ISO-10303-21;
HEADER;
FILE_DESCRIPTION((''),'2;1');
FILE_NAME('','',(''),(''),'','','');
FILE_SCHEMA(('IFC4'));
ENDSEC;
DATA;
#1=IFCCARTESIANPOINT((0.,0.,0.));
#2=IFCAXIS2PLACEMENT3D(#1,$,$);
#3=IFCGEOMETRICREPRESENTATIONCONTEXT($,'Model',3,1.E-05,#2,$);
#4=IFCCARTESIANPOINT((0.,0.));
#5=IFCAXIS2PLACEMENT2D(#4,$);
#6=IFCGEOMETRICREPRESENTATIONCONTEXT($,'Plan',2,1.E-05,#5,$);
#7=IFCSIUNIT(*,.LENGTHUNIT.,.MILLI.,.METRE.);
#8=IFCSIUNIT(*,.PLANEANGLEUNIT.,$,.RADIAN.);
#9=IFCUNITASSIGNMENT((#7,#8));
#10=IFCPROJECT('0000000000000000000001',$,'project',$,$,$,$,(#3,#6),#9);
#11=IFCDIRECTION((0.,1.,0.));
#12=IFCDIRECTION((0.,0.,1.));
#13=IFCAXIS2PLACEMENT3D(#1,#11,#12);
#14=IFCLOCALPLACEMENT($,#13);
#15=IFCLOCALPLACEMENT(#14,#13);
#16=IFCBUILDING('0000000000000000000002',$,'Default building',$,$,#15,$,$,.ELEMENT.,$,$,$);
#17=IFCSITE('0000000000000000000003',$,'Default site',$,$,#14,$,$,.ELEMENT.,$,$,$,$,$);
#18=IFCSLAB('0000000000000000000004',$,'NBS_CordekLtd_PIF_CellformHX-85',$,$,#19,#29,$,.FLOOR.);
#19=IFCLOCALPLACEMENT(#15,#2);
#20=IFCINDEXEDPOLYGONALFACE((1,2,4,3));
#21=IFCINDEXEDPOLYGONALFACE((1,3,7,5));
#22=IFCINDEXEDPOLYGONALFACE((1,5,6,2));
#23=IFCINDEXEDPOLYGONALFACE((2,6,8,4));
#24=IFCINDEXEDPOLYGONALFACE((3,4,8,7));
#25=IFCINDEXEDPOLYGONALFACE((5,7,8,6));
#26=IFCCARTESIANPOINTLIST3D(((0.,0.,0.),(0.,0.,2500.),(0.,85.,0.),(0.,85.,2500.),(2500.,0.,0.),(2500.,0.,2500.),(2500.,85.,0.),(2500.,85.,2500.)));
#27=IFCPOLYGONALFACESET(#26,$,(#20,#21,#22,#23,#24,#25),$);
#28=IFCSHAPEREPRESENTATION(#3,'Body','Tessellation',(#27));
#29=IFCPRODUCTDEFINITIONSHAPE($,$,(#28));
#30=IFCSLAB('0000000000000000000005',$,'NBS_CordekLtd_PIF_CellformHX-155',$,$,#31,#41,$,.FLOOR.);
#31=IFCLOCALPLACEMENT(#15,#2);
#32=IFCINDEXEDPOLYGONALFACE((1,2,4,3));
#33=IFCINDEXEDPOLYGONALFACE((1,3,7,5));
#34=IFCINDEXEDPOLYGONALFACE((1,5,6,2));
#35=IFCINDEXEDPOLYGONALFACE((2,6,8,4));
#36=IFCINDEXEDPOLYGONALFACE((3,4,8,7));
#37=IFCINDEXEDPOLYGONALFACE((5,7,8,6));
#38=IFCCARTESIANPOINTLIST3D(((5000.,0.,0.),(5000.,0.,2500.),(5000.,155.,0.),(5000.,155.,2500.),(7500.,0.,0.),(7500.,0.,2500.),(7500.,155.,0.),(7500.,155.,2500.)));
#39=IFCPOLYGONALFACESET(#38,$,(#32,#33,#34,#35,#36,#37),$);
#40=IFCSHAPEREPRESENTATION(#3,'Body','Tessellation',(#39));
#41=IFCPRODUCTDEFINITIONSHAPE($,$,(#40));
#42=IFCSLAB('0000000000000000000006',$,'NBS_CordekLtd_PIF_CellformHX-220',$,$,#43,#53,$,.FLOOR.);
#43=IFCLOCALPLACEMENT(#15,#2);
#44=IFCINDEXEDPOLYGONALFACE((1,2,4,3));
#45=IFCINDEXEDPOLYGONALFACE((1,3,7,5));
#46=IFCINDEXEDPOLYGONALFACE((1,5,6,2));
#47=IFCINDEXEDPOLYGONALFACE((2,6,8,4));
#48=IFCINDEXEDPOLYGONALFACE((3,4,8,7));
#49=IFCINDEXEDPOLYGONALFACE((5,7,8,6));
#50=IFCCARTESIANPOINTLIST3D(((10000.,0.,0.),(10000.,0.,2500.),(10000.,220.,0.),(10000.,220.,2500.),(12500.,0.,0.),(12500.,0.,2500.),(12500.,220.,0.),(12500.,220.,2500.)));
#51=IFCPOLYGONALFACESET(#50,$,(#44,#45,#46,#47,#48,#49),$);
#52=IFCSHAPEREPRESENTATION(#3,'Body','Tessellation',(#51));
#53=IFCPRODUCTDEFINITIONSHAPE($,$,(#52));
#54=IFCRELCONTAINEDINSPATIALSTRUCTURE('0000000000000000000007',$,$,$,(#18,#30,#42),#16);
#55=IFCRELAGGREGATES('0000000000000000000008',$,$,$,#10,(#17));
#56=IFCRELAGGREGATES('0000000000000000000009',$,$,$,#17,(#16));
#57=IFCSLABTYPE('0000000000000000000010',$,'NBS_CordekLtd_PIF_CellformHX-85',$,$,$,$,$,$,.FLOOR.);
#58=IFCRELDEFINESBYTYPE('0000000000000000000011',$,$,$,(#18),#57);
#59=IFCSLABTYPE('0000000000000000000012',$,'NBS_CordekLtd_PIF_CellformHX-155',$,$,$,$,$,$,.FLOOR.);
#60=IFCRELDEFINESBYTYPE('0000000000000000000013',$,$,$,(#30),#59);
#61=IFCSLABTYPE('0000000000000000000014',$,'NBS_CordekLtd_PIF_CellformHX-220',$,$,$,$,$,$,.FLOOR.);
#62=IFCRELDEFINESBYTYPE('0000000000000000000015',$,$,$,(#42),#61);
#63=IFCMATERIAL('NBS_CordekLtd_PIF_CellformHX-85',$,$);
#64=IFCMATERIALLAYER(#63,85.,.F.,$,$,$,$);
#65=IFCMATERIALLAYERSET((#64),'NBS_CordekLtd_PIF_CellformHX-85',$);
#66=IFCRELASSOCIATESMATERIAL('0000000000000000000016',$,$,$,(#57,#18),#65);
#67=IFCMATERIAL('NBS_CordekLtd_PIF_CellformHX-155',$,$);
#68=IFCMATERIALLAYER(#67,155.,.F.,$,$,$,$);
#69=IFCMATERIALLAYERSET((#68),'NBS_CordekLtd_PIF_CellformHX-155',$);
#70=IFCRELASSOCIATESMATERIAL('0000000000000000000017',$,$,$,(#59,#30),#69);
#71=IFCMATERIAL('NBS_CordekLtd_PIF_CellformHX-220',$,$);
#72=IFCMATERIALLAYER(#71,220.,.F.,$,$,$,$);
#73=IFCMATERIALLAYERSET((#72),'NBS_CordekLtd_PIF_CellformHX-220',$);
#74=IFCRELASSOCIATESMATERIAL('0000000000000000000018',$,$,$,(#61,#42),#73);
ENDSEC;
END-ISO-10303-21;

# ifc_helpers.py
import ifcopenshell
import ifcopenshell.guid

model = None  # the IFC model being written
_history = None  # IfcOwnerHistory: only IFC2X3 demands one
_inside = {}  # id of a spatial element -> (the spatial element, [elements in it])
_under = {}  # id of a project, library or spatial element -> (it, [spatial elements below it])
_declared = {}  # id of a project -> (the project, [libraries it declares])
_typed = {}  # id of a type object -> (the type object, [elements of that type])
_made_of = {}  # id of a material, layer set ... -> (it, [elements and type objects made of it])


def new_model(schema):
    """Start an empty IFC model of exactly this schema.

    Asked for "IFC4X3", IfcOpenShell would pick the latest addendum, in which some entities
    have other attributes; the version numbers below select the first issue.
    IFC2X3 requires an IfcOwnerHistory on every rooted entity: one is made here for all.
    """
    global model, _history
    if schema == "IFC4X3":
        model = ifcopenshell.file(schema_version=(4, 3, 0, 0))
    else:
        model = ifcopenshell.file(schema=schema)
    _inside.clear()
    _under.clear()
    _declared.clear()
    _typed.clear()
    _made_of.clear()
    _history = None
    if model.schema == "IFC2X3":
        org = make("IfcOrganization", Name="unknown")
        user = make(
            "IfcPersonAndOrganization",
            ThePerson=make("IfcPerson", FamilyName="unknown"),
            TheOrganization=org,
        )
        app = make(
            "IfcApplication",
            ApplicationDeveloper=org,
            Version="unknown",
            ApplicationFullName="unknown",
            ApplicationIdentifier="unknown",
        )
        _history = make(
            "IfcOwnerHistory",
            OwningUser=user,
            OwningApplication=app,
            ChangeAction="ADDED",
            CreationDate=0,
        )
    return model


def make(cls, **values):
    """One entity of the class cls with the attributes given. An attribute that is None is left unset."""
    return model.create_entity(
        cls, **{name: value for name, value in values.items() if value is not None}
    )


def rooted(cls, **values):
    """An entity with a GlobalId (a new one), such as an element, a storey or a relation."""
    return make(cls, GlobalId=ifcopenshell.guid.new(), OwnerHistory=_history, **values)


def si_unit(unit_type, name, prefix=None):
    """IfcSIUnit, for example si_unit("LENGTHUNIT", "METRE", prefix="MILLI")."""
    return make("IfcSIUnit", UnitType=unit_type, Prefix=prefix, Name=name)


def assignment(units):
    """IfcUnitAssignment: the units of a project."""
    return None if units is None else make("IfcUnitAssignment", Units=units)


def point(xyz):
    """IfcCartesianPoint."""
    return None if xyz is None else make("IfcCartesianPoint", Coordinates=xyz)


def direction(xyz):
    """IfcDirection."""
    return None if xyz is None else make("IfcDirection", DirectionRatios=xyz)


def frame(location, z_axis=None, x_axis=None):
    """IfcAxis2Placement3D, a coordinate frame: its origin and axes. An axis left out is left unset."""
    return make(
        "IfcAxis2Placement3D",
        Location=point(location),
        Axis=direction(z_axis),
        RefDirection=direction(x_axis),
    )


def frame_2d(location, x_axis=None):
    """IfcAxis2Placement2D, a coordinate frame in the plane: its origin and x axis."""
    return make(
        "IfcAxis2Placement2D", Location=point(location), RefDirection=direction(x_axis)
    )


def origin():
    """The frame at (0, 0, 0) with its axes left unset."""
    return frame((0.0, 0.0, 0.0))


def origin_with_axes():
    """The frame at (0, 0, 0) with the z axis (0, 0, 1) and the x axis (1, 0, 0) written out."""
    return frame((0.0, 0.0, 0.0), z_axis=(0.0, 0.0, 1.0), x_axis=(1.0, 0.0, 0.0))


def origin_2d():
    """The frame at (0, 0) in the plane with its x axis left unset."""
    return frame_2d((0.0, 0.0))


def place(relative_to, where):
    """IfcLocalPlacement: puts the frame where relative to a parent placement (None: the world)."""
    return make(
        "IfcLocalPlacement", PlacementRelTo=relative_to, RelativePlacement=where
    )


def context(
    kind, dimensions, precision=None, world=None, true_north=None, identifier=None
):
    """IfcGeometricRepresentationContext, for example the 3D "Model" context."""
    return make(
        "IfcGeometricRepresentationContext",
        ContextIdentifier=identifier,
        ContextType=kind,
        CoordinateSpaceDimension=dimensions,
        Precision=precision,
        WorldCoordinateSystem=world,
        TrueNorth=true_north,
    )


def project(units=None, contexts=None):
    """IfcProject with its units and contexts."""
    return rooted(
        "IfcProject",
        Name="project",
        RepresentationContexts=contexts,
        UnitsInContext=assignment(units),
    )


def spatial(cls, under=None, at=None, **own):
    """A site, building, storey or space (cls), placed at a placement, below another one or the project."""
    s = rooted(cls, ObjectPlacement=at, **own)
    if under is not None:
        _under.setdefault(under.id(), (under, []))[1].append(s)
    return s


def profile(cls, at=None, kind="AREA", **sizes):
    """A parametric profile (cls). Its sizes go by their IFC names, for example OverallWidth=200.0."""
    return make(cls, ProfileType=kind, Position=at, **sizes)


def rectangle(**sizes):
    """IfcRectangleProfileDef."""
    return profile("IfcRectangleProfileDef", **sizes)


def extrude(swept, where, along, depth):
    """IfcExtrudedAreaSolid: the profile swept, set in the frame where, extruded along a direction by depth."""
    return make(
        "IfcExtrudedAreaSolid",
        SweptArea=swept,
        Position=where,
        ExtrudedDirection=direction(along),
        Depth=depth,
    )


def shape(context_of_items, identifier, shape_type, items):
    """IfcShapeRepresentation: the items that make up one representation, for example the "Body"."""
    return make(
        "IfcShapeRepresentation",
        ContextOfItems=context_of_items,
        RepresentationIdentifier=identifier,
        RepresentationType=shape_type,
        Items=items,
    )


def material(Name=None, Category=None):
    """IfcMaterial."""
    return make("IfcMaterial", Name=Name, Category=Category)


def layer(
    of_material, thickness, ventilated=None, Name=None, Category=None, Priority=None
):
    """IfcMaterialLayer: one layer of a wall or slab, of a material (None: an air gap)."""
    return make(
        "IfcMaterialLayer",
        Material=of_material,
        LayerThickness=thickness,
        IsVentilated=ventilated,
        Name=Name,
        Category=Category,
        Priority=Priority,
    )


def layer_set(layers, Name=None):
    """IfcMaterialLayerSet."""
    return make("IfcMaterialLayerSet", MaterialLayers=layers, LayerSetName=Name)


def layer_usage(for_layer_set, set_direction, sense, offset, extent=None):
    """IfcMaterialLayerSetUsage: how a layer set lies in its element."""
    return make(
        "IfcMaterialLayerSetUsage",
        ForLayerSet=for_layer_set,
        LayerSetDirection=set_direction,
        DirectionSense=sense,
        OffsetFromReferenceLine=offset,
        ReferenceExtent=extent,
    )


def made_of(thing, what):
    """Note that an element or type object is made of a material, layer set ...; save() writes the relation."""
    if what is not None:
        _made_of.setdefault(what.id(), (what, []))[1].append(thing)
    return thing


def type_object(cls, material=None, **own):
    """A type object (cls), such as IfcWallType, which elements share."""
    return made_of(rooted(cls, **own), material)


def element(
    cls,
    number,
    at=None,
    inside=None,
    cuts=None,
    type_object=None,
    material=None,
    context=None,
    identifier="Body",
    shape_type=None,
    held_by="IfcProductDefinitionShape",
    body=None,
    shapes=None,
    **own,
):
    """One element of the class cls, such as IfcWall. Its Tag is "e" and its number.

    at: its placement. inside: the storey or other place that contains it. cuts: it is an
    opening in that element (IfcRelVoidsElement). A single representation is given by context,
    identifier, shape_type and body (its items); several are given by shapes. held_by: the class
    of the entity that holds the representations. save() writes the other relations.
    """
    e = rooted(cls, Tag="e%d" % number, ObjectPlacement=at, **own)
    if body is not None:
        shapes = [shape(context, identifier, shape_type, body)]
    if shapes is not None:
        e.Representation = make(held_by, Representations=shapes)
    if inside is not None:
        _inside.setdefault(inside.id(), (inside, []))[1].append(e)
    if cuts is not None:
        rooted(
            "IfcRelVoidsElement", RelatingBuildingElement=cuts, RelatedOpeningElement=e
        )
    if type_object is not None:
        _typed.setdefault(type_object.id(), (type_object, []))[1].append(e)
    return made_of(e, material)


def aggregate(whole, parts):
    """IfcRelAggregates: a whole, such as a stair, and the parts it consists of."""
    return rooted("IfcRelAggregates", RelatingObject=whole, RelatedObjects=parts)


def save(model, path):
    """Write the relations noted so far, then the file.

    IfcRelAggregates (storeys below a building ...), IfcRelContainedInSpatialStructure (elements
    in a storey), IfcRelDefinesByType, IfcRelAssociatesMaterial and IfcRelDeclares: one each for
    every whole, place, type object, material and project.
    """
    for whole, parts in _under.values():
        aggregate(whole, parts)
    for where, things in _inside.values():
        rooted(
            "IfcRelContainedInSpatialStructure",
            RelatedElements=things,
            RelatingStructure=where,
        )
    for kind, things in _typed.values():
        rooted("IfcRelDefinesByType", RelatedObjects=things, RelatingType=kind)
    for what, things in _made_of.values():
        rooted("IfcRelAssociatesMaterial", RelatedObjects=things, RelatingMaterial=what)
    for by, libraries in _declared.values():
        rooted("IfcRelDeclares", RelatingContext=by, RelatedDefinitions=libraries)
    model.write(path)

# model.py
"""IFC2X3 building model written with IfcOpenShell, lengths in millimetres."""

from ifc_helpers import new_model, si_unit, frame, frame_2d, origin, origin_with_axes, origin_2d, place, context, project, spatial, rectangle, extrude, material, layer, layer_set, layer_usage, type_object, element, save


model = new_model("IFC2X3")

# Units and contexts
model_context = context("Model", 3, precision=1e-05, world=origin())
plan_context = context("Plan", 2, precision=1e-05, world=origin_2d())
ifc_project = project(units=[si_unit("LENGTHUNIT", "METRE", prefix="MILLI"), si_unit("PLANEANGLEUNIT", "RADIAN")], contexts=[model_context, plan_context])

# Site, building
site_placement = place(None, frame((0.0, 0.0, 0.0), z_axis=(0.0, 1.0, 0.0), x_axis=(0.0, 0.0, 1.0)))
site = spatial("IfcSite", under=ifc_project, at=site_placement, Name="Default site", CompositionType="ELEMENT")
building_placement = place(site_placement, frame((0.0, 0.0, 0.0), z_axis=(0.0, 1.0, 0.0), x_axis=(0.0, 0.0, 1.0)))
building = spatial("IfcBuilding", under=site, at=building_placement, Name="Default building", CompositionType="ELEMENT")

# Slabs
ifc_material_1 = material(Name="NBS_CordekLtd_PIF_CellformHX-85")
ifc_layer_1 = layer(ifc_material_1, 85.0, ventilated=False)
ifc_layer_set_1 = layer_set([ifc_layer_1], Name="NBS_CordekLtd_PIF_CellformHX-85")
ifc_layer_usage_1 = layer_usage(ifc_layer_set_1, "AXIS3", "NEGATIVE", 0.0)
slab_type_1 = type_object("IfcSlabType", Name="NBS_CordekLtd_PIF_CellformHX-85", PredefinedType="FLOOR", material=ifc_layer_set_1)
slab_1_placement = place(None, origin())
element("IfcSlab", 1, at=slab_1_placement, inside=building, type_object=slab_type_1, material=ifc_layer_usage_1, Name="NBS_CordekLtd_PIF_CellformHX-85", PredefinedType="FLOOR", context=model_context, shape_type="SweptSolid", body=[
    extrude(rectangle(XDim=2500.0, YDim=2500.0, at=frame_2d((1250.0, 1250.0))), origin_with_axes(), (0.0, 0.0, 1.0), 85.0),
])
ifc_material_2 = material(Name="NBS_CordekLtd_PIF_CellformHX-155")
ifc_layer_2 = layer(ifc_material_2, 155.0, ventilated=False)
ifc_layer_set_2 = layer_set([ifc_layer_2], Name="NBS_CordekLtd_PIF_CellformHX-155")
ifc_layer_usage_2 = layer_usage(ifc_layer_set_2, "AXIS3", "NEGATIVE", 0.0)
slab_type_2 = type_object("IfcSlabType", Name="NBS_CordekLtd_PIF_CellformHX-155", PredefinedType="FLOOR", material=ifc_layer_set_2)
slab_2_placement = place(None, frame((0.0, 5000.0, 0.0)))
element("IfcSlab", 2, at=slab_2_placement, inside=building, type_object=slab_type_2, material=ifc_layer_usage_2, Name="NBS_CordekLtd_PIF_CellformHX-155", PredefinedType="FLOOR", context=model_context, shape_type="SweptSolid", body=[
    extrude(rectangle(XDim=2500.0, YDim=2500.0, at=frame_2d((1250.0, 1250.0))), origin_with_axes(), (0.0, 0.0, 1.0), 155.0),
])
ifc_material_3 = material(Name="NBS_CordekLtd_PIF_CellformHX-220")
ifc_layer_3 = layer(ifc_material_3, 220.0, ventilated=False)
ifc_layer_set_3 = layer_set([ifc_layer_3], Name="NBS_CordekLtd_PIF_CellformHX-220")
ifc_layer_usage_3 = layer_usage(ifc_layer_set_3, "AXIS3", "NEGATIVE", 0.0)
slab_type_3 = type_object("IfcSlabType", Name="NBS_CordekLtd_PIF_CellformHX-220", PredefinedType="FLOOR", material=ifc_layer_set_3)
slab_3_placement = place(None, frame((0.0, 10000.0, 0.0)))
element("IfcSlab", 3, at=slab_3_placement, inside=building, type_object=slab_type_3, material=ifc_layer_usage_3, Name="NBS_CordekLtd_PIF_CellformHX-220", PredefinedType="FLOOR", context=model_context, shape_type="SweptSolid", body=[
    extrude(rectangle(XDim=2500.0, YDim=2500.0, at=frame_2d((1250.0, 1250.0))), origin_with_axes(), (0.0, 0.0, 1.0), 220.0),
])

save(model, "model.ifc")
